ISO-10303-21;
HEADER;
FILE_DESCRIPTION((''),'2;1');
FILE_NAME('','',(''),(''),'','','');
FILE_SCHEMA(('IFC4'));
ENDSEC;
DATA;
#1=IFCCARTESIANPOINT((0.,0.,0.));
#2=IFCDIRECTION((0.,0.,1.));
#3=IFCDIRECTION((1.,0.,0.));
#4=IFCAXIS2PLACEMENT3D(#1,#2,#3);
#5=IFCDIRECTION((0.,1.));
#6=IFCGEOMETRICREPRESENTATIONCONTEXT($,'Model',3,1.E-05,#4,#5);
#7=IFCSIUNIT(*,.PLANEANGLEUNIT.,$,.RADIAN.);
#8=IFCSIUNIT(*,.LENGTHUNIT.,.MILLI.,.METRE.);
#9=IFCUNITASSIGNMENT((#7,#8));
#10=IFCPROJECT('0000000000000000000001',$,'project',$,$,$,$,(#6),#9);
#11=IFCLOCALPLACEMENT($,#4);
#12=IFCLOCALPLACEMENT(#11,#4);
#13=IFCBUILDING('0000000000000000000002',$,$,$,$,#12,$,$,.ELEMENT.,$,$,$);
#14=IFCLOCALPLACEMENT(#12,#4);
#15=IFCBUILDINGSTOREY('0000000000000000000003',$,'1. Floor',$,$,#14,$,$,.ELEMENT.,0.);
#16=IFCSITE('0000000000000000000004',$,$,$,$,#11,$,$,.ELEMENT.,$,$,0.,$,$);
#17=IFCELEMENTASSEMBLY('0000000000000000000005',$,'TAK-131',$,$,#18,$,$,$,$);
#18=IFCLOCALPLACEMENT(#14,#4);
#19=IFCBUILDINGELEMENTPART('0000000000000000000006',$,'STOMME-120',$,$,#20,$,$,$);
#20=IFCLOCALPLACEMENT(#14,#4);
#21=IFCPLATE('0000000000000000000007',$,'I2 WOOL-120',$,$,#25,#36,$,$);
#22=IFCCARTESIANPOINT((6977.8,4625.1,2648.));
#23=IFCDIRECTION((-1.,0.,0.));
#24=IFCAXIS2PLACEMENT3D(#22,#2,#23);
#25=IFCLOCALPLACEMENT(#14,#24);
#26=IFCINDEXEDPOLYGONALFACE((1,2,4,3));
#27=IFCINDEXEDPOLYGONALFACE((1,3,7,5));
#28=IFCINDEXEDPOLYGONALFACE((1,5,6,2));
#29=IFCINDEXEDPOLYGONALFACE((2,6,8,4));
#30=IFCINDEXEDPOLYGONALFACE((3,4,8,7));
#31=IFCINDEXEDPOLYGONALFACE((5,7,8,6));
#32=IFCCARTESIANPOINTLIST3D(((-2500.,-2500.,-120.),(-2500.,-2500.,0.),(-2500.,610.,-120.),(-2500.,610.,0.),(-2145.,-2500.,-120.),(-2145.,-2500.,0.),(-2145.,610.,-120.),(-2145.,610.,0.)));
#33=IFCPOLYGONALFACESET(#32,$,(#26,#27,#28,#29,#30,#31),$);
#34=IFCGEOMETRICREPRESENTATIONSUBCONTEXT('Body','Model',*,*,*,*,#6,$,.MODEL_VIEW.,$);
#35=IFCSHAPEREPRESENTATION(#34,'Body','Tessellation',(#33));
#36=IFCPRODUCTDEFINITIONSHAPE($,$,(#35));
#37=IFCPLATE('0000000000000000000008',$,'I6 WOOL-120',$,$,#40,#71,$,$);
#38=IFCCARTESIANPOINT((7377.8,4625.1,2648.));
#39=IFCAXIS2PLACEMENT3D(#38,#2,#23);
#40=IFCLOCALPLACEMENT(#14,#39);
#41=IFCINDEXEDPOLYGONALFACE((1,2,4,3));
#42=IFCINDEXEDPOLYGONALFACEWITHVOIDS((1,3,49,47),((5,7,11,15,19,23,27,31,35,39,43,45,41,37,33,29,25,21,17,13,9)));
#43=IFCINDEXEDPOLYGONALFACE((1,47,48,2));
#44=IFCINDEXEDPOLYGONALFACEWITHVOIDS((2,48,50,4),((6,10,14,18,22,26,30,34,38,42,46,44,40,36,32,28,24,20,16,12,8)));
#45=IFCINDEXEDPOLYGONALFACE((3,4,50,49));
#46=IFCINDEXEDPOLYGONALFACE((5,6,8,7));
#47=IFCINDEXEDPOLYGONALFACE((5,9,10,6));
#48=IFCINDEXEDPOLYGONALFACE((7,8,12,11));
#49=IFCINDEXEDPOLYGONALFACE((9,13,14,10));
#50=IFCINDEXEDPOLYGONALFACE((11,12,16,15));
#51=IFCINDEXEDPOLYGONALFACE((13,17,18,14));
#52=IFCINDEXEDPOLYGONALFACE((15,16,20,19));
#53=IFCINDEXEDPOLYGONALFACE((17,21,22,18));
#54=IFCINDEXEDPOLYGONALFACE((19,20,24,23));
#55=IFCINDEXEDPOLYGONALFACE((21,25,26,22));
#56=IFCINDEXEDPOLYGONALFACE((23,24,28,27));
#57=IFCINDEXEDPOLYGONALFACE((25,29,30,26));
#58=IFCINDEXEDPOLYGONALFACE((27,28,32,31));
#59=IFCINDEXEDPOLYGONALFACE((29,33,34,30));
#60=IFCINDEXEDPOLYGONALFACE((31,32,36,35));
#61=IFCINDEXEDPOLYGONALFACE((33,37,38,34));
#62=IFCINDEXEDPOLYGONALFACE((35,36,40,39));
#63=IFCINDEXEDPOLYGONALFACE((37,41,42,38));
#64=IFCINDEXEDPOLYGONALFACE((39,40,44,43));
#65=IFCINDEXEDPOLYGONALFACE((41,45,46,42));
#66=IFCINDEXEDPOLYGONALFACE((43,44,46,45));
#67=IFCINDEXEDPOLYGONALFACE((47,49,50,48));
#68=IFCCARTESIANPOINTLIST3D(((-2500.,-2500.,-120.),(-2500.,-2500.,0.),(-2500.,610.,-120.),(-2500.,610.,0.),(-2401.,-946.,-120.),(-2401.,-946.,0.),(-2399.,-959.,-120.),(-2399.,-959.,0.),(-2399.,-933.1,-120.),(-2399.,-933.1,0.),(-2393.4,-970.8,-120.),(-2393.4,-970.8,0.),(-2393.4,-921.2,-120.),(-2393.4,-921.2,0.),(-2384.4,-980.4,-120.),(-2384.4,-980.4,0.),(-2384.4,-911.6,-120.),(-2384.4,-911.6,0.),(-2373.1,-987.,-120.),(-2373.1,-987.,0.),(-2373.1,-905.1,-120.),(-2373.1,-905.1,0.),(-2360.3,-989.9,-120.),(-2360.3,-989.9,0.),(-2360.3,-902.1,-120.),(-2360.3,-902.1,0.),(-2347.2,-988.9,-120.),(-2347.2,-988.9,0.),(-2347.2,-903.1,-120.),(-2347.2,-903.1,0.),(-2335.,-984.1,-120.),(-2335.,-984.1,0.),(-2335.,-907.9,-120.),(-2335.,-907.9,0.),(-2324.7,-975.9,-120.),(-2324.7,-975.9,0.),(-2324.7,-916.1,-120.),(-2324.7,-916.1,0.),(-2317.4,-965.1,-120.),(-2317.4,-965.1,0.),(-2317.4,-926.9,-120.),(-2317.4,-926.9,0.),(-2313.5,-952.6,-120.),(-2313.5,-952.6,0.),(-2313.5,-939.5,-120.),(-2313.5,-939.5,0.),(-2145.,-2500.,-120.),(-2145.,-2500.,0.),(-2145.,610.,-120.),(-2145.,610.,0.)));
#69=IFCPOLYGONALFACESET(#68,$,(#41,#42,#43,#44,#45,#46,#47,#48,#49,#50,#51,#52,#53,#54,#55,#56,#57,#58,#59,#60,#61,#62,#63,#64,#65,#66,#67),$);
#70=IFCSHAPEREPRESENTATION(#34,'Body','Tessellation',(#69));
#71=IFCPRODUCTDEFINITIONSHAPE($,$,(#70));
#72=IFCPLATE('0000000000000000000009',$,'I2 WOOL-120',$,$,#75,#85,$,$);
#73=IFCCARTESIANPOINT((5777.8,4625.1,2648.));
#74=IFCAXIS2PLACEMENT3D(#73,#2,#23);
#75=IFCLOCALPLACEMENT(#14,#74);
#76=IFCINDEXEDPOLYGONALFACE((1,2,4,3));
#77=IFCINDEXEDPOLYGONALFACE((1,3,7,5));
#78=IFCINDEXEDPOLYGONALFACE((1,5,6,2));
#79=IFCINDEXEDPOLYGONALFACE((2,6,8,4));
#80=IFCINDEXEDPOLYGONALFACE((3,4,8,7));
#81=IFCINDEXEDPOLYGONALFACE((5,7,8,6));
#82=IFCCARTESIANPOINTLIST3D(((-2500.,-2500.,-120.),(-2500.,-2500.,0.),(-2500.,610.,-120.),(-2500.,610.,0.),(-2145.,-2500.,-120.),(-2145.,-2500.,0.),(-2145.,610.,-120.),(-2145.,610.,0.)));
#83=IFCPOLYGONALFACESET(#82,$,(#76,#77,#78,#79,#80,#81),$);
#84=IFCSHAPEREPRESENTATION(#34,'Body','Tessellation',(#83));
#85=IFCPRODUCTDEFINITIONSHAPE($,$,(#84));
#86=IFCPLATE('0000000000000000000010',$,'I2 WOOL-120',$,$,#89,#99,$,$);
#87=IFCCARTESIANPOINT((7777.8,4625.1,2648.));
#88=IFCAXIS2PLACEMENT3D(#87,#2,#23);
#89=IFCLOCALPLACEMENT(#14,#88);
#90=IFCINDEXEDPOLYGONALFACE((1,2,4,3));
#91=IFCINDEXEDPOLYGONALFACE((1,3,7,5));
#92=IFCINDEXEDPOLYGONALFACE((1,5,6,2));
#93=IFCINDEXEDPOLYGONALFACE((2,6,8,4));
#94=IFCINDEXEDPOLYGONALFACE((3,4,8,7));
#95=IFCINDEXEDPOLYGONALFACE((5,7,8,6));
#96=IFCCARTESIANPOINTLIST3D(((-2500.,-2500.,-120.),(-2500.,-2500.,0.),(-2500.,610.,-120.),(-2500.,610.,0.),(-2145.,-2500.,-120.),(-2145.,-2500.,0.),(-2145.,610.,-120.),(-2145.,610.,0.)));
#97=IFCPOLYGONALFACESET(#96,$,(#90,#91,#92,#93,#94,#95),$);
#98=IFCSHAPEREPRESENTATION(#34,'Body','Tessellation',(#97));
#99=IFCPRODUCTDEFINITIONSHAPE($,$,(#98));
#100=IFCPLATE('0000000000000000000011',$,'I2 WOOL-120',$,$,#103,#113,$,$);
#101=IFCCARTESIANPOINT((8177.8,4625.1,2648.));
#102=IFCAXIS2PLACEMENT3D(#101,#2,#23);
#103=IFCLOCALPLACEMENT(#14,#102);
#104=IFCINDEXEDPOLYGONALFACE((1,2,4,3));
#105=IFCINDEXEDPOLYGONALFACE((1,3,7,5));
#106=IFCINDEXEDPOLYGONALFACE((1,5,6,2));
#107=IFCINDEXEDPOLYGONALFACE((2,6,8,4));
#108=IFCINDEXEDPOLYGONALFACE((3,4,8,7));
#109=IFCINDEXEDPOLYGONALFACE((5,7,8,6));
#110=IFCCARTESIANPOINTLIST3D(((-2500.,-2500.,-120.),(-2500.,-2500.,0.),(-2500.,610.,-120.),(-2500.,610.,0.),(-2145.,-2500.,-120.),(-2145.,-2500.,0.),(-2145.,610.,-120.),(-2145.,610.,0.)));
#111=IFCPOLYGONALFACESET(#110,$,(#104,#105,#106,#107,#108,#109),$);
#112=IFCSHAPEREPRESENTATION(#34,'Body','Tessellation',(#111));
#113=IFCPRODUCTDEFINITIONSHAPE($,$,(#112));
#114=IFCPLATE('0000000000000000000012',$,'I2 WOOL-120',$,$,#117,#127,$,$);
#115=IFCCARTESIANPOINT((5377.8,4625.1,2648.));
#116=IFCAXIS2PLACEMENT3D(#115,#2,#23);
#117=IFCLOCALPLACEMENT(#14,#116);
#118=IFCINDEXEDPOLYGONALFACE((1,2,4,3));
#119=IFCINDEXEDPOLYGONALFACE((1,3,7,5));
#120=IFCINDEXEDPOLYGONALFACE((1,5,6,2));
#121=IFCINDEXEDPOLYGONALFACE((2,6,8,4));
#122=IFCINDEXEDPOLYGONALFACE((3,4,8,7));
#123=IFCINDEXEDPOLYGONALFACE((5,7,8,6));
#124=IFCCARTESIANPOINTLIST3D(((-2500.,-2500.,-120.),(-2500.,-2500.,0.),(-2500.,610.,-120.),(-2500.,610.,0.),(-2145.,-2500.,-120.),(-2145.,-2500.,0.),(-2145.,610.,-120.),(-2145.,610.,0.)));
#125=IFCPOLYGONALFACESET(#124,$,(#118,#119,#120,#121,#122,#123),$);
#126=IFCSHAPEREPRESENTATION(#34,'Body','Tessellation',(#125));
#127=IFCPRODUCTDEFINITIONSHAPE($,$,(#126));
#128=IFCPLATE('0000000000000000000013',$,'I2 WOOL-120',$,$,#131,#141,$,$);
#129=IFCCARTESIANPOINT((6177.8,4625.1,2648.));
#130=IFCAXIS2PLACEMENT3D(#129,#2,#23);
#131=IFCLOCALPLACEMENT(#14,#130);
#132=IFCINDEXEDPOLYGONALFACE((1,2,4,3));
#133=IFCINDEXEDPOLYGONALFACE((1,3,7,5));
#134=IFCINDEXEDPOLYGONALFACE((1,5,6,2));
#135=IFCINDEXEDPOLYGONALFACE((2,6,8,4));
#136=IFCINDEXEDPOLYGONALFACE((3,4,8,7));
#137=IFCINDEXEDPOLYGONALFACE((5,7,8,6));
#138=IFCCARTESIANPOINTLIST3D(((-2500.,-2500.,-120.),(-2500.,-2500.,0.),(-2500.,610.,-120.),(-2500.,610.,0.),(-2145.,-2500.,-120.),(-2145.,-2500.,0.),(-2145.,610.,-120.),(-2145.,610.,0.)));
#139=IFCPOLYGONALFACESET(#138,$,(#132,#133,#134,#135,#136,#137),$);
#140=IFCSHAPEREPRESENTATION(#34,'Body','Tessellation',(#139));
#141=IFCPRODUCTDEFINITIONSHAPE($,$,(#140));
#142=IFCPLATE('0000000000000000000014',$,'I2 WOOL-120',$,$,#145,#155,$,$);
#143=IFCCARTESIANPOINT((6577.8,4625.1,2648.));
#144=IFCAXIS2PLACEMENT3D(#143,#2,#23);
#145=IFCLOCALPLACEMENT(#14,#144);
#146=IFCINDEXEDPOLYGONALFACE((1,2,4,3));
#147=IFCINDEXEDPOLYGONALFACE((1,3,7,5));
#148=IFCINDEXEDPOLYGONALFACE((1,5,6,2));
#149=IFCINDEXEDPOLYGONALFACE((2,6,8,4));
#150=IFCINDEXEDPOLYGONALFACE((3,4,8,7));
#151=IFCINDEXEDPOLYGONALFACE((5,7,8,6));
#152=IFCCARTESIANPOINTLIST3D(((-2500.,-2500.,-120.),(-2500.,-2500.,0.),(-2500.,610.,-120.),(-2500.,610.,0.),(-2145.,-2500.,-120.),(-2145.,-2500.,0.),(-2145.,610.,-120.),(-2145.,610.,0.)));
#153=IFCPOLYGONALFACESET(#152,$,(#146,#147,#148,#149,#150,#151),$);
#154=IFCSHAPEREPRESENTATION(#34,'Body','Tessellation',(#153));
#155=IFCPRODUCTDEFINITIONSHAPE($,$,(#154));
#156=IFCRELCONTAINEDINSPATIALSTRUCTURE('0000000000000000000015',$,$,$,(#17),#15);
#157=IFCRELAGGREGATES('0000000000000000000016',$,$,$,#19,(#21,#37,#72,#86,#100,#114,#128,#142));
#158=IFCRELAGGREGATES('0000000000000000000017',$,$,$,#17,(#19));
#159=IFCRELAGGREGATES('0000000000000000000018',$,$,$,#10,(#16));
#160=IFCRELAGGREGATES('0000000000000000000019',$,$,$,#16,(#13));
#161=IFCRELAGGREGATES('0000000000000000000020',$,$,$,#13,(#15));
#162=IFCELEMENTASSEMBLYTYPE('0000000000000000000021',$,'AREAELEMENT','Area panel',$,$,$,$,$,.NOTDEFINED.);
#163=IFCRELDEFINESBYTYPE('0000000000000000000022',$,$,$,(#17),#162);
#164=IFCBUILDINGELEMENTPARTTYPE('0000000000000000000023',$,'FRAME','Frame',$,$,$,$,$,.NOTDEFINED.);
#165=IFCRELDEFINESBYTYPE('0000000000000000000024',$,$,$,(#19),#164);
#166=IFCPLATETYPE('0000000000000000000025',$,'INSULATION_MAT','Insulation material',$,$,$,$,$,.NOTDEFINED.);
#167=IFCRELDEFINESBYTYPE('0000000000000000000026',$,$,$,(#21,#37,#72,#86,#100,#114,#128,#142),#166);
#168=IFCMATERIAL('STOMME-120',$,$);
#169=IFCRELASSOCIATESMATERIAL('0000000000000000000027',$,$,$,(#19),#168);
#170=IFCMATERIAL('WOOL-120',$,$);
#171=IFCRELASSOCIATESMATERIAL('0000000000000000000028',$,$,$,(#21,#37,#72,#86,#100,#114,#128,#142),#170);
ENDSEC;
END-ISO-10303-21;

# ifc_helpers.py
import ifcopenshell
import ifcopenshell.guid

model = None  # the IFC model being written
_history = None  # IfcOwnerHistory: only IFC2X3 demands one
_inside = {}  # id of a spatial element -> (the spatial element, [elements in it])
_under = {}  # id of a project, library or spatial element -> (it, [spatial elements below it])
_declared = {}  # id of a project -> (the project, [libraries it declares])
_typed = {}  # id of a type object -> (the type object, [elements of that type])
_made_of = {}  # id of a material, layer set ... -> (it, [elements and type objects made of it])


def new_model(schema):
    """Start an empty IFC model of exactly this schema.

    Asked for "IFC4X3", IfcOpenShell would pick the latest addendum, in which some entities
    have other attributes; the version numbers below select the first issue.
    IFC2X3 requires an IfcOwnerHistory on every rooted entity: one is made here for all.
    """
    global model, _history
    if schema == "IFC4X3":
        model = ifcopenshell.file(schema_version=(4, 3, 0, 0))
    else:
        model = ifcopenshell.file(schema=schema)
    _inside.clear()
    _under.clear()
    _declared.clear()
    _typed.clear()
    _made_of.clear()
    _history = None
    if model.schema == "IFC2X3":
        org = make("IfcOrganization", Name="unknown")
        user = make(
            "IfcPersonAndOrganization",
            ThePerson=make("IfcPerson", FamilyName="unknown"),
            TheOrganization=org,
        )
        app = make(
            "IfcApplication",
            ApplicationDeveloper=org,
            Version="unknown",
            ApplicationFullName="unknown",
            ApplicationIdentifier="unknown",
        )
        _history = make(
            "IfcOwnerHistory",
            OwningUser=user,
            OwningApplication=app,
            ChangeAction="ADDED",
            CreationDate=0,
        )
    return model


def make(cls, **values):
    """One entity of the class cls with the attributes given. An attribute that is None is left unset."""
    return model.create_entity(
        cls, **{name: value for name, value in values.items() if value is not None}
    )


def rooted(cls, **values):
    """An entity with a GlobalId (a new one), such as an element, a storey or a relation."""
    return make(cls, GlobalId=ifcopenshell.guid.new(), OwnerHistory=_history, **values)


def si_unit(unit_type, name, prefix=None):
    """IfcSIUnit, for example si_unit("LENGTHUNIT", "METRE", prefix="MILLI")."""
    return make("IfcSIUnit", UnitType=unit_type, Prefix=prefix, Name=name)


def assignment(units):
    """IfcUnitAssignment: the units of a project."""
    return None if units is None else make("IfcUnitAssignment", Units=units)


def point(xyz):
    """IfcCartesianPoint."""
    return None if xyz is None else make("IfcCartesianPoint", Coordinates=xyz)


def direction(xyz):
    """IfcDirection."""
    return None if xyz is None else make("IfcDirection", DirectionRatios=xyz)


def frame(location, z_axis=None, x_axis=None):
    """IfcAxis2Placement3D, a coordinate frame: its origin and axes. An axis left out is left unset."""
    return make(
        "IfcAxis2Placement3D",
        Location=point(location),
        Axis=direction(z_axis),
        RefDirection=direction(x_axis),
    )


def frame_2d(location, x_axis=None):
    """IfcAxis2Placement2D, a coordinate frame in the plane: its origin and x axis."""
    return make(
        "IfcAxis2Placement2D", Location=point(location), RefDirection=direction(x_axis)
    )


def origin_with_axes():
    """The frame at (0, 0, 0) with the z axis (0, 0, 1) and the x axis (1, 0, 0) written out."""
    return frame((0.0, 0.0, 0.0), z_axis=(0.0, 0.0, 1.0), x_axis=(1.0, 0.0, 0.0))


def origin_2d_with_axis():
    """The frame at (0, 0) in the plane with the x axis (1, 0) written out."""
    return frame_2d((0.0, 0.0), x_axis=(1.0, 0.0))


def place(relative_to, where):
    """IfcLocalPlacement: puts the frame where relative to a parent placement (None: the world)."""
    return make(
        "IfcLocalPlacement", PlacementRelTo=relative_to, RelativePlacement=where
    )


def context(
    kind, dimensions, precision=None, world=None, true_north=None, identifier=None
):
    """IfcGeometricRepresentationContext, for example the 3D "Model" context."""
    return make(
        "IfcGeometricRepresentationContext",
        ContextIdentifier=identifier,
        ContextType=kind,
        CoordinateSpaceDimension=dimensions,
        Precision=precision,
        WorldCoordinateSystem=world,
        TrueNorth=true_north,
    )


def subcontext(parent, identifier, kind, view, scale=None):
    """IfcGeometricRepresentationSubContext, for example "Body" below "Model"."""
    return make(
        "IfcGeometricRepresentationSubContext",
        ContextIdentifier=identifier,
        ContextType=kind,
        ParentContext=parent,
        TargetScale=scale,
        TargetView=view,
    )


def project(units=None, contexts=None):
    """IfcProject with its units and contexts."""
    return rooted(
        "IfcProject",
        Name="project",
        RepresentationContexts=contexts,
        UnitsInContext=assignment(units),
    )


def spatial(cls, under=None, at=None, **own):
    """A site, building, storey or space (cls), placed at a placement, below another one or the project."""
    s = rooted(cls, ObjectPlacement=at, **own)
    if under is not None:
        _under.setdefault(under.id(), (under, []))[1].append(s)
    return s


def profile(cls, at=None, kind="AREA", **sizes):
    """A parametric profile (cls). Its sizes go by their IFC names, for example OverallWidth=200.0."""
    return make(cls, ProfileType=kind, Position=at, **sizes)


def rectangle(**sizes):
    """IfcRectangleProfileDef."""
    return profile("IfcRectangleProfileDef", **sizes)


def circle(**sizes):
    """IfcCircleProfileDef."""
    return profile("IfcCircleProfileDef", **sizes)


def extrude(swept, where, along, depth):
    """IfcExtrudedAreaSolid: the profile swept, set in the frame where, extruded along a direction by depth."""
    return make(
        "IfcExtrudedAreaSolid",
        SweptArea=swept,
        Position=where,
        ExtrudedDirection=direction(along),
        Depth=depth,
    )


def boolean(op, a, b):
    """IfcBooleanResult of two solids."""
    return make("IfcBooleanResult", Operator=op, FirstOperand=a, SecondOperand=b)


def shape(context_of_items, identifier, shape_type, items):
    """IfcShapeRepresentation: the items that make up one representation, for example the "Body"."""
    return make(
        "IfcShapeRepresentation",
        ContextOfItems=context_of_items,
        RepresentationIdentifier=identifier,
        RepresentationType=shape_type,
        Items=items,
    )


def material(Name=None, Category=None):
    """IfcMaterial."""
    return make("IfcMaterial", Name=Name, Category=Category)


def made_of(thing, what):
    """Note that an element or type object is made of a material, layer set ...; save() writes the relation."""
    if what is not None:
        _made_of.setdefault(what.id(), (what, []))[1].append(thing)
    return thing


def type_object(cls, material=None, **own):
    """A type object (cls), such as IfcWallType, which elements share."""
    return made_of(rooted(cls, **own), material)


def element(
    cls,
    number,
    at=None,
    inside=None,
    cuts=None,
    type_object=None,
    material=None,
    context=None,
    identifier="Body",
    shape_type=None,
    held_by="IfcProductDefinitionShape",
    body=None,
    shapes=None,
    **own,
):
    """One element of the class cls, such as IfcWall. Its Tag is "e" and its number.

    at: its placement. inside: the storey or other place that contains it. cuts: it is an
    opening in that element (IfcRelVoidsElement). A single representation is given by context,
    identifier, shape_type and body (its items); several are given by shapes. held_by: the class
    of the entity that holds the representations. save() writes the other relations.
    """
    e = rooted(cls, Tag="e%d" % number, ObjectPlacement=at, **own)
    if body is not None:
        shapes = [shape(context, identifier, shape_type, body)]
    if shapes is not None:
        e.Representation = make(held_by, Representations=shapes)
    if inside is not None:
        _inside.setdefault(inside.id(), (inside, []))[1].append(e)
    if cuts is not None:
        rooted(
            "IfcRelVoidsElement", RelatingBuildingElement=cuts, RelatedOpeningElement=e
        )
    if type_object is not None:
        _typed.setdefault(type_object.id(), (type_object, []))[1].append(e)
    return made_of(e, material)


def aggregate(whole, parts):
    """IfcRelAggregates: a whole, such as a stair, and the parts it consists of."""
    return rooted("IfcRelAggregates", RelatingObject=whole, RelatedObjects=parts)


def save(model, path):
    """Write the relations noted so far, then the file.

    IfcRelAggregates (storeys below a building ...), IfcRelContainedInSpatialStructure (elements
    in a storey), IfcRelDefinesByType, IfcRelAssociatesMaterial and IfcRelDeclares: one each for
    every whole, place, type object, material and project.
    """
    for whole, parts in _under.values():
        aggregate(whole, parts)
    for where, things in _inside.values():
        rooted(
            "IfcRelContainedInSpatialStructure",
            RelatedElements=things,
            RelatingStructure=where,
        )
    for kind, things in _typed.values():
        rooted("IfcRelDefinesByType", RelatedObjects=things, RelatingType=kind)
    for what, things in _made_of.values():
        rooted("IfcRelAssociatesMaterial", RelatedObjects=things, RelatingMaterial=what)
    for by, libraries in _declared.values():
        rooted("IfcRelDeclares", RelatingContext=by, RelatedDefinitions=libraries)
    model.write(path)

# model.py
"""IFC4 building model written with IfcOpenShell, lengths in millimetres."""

from ifc_helpers import new_model, si_unit, direction, frame, origin_with_axes, origin_2d_with_axis, place, context, subcontext, project, spatial, rectangle, circle, extrude, boolean, material, type_object, element, aggregate, save


model = new_model("IFC4")

# Units and contexts
model_context = context("Model", 3, precision=1e-05, world=origin_with_axes(), true_north=direction((0.0, 1.0)))
body_context = subcontext(model_context, "Body", "Model", "MODEL_VIEW")
ifc_project = project(units=[si_unit("PLANEANGLEUNIT", "RADIAN"), si_unit("LENGTHUNIT", "METRE", prefix="MILLI")], contexts=[model_context])

# Site, building, storey
site_placement = place(None, origin_with_axes())
site = spatial("IfcSite", under=ifc_project, at=site_placement, CompositionType="ELEMENT", RefElevation=0.0)
building_placement = place(site_placement, origin_with_axes())
building = spatial("IfcBuilding", under=site, at=building_placement, CompositionType="ELEMENT")
storey_placement = place(building_placement, origin_with_axes())
storey = spatial("IfcBuildingStorey", under=building, at=storey_placement, Name="1. Floor", CompositionType="ELEMENT", Elevation=0.0)

# Element assembly, building element part, plates
element_assembly_type_1 = type_object("IfcElementAssemblyType", Name="AREAELEMENT", Description="Area panel", PredefinedType="NOTDEFINED")
assembly_1_placement = place(storey_placement, origin_with_axes())
assembly_1 = element("IfcElementAssembly", 1, at=assembly_1_placement, inside=storey, type_object=element_assembly_type_1, Name="TAK-131")
ifc_material_1 = material(Name="STOMME-120")
building_element_part_type_1 = type_object("IfcBuildingElementPartType", Name="FRAME", Description="Frame", PredefinedType="NOTDEFINED")
building_element_part_1_placement = place(storey_placement, origin_with_axes())
building_element_part_1 = element("IfcBuildingElementPart", 2, at=building_element_part_1_placement, type_object=building_element_part_type_1, material=ifc_material_1, Name="STOMME-120")
ifc_material_2 = material(Name="WOOL-120")
plate_type_1 = type_object("IfcPlateType", Name="INSULATION_MAT", Description="Insulation material", PredefinedType="NOTDEFINED")
plate_1_placement = place(storey_placement, frame((6977.8, 4625.1, 2648.0), z_axis=(0.0, 0.0, 1.0), x_axis=(-1.0, 0.0, 0.0)))
plate_1 = element("IfcPlate", 3, at=plate_1_placement, type_object=plate_type_1, material=ifc_material_2, Name="I2 WOOL-120", context=body_context, shape_type="SweptSolid", body=[
    extrude(rectangle(XDim=120.0, YDim=355.0, at=origin_2d_with_axis()), frame((-2322.5, -2500.0, -60.0), z_axis=(0.0, 1.0, 0.0), x_axis=(0.0, 0.0, 1.0)), (0.0, 0.0, 1.0), 3110.0),
])
plate_2_placement = place(storey_placement, frame((7377.8, 4625.1, 2648.0), z_axis=(0.0, 0.0, 1.0), x_axis=(-1.0, 0.0, 0.0)))
plate_2 = element("IfcPlate", 4, at=plate_2_placement, type_object=plate_type_1, material=ifc_material_2, Name="I6 WOOL-120", context=body_context, shape_type="CSG", body=[
    boolean("DIFFERENCE", boolean("DIFFERENCE", extrude(rectangle(XDim=120.0, YDim=355.0, at=origin_2d_with_axis()), frame((-2322.5, -2500.0, -60.0), z_axis=(0.0, 1.0, 0.0), x_axis=(0.0, 0.0, 1.0)), (0.0, 0.0, 1.0), 3110.0), extrude(circle(Radius=44.0, at=origin_2d_with_axis()), frame((-2357.0, -946.0, 5.0), z_axis=(0.0, 0.0, 1.0), x_axis=(-1.0, 0.0, 0.0)), (0.0, 0.0, -1.0), 160.0)), extrude(circle(Radius=44.0, at=origin_2d_with_axis()), frame((-2357.0, -946.0, 5.0), z_axis=(0.0, 0.0, 1.0), x_axis=(-1.0, 0.0, 0.0)), (0.0, 0.0, -1.0), 160.0)),
])
plate_3_placement = place(storey_placement, frame((5777.8, 4625.1, 2648.0), z_axis=(0.0, 0.0, 1.0), x_axis=(-1.0, 0.0, 0.0)))
plate_3 = element("IfcPlate", 5, at=plate_3_placement, type_object=plate_type_1, material=ifc_material_2, Name="I2 WOOL-120", context=body_context, shape_type="SweptSolid", body=[
    extrude(rectangle(XDim=120.0, YDim=355.0, at=origin_2d_with_axis()), frame((-2322.5, -2500.0, -60.0), z_axis=(0.0, 1.0, 0.0), x_axis=(0.0, 0.0, 1.0)), (0.0, 0.0, 1.0), 3110.0),
])
plate_4_placement = place(storey_placement, frame((7777.8, 4625.1, 2648.0), z_axis=(0.0, 0.0, 1.0), x_axis=(-1.0, 0.0, 0.0)))
plate_4 = element("IfcPlate", 6, at=plate_4_placement, type_object=plate_type_1, material=ifc_material_2, Name="I2 WOOL-120", context=body_context, shape_type="SweptSolid", body=[
    extrude(rectangle(XDim=120.0, YDim=355.0, at=origin_2d_with_axis()), frame((-2322.5, -2500.0, -60.0), z_axis=(0.0, 1.0, 0.0), x_axis=(0.0, 0.0, 1.0)), (0.0, 0.0, 1.0), 3110.0),
])
plate_5_placement = place(storey_placement, frame((8177.8, 4625.1, 2648.0), z_axis=(0.0, 0.0, 1.0), x_axis=(-1.0, 0.0, 0.0)))
plate_5 = element("IfcPlate", 7, at=plate_5_placement, type_object=plate_type_1, material=ifc_material_2, Name="I2 WOOL-120", context=body_context, shape_type="SweptSolid", body=[
    extrude(rectangle(XDim=120.0, YDim=355.0, at=origin_2d_with_axis()), frame((-2322.5, -2500.0, -60.0), z_axis=(0.0, 1.0, 0.0), x_axis=(0.0, 0.0, 1.0)), (0.0, 0.0, 1.0), 3110.0),
])
plate_6_placement = place(storey_placement, frame((5377.8, 4625.1, 2648.0), z_axis=(0.0, 0.0, 1.0), x_axis=(-1.0, 0.0, 0.0)))
plate_6 = element("IfcPlate", 8, at=plate_6_placement, type_object=plate_type_1, material=ifc_material_2, Name="I2 WOOL-120", context=body_context, shape_type="SweptSolid", body=[
    extrude(rectangle(XDim=120.0, YDim=355.0, at=origin_2d_with_axis()), frame((-2322.5, -2500.0, -60.0), z_axis=(0.0, 1.0, 0.0), x_axis=(0.0, 0.0, 1.0)), (0.0, 0.0, 1.0), 3110.0),
])
plate_7_placement = place(storey_placement, frame((6177.8, 4625.1, 2648.0), z_axis=(0.0, 0.0, 1.0), x_axis=(-1.0, 0.0, 0.0)))
plate_7 = element("IfcPlate", 9, at=plate_7_placement, type_object=plate_type_1, material=ifc_material_2, Name="I2 WOOL-120", context=body_context, shape_type="SweptSolid", body=[
    extrude(rectangle(XDim=120.0, YDim=355.0, at=origin_2d_with_axis()), frame((-2322.5, -2500.0, -60.0), z_axis=(0.0, 1.0, 0.0), x_axis=(0.0, 0.0, 1.0)), (0.0, 0.0, 1.0), 3110.0),
])
plate_8_placement = place(storey_placement, frame((6577.8, 4625.1, 2648.0), z_axis=(0.0, 0.0, 1.0), x_axis=(-1.0, 0.0, 0.0)))
plate_8 = element("IfcPlate", 10, at=plate_8_placement, type_object=plate_type_1, material=ifc_material_2, Name="I2 WOOL-120", context=body_context, shape_type="SweptSolid", body=[
    extrude(rectangle(XDim=120.0, YDim=355.0, at=origin_2d_with_axis()), frame((-2322.5, -2500.0, -60.0), z_axis=(0.0, 1.0, 0.0), x_axis=(0.0, 0.0, 1.0)), (0.0, 0.0, 1.0), 3110.0),
])
aggregate(building_element_part_1, [plate_1, plate_2, plate_3, plate_4, plate_5, plate_6, plate_7, plate_8])

aggregate(assembly_1, [building_element_part_1])

save(model, "model.ifc")
